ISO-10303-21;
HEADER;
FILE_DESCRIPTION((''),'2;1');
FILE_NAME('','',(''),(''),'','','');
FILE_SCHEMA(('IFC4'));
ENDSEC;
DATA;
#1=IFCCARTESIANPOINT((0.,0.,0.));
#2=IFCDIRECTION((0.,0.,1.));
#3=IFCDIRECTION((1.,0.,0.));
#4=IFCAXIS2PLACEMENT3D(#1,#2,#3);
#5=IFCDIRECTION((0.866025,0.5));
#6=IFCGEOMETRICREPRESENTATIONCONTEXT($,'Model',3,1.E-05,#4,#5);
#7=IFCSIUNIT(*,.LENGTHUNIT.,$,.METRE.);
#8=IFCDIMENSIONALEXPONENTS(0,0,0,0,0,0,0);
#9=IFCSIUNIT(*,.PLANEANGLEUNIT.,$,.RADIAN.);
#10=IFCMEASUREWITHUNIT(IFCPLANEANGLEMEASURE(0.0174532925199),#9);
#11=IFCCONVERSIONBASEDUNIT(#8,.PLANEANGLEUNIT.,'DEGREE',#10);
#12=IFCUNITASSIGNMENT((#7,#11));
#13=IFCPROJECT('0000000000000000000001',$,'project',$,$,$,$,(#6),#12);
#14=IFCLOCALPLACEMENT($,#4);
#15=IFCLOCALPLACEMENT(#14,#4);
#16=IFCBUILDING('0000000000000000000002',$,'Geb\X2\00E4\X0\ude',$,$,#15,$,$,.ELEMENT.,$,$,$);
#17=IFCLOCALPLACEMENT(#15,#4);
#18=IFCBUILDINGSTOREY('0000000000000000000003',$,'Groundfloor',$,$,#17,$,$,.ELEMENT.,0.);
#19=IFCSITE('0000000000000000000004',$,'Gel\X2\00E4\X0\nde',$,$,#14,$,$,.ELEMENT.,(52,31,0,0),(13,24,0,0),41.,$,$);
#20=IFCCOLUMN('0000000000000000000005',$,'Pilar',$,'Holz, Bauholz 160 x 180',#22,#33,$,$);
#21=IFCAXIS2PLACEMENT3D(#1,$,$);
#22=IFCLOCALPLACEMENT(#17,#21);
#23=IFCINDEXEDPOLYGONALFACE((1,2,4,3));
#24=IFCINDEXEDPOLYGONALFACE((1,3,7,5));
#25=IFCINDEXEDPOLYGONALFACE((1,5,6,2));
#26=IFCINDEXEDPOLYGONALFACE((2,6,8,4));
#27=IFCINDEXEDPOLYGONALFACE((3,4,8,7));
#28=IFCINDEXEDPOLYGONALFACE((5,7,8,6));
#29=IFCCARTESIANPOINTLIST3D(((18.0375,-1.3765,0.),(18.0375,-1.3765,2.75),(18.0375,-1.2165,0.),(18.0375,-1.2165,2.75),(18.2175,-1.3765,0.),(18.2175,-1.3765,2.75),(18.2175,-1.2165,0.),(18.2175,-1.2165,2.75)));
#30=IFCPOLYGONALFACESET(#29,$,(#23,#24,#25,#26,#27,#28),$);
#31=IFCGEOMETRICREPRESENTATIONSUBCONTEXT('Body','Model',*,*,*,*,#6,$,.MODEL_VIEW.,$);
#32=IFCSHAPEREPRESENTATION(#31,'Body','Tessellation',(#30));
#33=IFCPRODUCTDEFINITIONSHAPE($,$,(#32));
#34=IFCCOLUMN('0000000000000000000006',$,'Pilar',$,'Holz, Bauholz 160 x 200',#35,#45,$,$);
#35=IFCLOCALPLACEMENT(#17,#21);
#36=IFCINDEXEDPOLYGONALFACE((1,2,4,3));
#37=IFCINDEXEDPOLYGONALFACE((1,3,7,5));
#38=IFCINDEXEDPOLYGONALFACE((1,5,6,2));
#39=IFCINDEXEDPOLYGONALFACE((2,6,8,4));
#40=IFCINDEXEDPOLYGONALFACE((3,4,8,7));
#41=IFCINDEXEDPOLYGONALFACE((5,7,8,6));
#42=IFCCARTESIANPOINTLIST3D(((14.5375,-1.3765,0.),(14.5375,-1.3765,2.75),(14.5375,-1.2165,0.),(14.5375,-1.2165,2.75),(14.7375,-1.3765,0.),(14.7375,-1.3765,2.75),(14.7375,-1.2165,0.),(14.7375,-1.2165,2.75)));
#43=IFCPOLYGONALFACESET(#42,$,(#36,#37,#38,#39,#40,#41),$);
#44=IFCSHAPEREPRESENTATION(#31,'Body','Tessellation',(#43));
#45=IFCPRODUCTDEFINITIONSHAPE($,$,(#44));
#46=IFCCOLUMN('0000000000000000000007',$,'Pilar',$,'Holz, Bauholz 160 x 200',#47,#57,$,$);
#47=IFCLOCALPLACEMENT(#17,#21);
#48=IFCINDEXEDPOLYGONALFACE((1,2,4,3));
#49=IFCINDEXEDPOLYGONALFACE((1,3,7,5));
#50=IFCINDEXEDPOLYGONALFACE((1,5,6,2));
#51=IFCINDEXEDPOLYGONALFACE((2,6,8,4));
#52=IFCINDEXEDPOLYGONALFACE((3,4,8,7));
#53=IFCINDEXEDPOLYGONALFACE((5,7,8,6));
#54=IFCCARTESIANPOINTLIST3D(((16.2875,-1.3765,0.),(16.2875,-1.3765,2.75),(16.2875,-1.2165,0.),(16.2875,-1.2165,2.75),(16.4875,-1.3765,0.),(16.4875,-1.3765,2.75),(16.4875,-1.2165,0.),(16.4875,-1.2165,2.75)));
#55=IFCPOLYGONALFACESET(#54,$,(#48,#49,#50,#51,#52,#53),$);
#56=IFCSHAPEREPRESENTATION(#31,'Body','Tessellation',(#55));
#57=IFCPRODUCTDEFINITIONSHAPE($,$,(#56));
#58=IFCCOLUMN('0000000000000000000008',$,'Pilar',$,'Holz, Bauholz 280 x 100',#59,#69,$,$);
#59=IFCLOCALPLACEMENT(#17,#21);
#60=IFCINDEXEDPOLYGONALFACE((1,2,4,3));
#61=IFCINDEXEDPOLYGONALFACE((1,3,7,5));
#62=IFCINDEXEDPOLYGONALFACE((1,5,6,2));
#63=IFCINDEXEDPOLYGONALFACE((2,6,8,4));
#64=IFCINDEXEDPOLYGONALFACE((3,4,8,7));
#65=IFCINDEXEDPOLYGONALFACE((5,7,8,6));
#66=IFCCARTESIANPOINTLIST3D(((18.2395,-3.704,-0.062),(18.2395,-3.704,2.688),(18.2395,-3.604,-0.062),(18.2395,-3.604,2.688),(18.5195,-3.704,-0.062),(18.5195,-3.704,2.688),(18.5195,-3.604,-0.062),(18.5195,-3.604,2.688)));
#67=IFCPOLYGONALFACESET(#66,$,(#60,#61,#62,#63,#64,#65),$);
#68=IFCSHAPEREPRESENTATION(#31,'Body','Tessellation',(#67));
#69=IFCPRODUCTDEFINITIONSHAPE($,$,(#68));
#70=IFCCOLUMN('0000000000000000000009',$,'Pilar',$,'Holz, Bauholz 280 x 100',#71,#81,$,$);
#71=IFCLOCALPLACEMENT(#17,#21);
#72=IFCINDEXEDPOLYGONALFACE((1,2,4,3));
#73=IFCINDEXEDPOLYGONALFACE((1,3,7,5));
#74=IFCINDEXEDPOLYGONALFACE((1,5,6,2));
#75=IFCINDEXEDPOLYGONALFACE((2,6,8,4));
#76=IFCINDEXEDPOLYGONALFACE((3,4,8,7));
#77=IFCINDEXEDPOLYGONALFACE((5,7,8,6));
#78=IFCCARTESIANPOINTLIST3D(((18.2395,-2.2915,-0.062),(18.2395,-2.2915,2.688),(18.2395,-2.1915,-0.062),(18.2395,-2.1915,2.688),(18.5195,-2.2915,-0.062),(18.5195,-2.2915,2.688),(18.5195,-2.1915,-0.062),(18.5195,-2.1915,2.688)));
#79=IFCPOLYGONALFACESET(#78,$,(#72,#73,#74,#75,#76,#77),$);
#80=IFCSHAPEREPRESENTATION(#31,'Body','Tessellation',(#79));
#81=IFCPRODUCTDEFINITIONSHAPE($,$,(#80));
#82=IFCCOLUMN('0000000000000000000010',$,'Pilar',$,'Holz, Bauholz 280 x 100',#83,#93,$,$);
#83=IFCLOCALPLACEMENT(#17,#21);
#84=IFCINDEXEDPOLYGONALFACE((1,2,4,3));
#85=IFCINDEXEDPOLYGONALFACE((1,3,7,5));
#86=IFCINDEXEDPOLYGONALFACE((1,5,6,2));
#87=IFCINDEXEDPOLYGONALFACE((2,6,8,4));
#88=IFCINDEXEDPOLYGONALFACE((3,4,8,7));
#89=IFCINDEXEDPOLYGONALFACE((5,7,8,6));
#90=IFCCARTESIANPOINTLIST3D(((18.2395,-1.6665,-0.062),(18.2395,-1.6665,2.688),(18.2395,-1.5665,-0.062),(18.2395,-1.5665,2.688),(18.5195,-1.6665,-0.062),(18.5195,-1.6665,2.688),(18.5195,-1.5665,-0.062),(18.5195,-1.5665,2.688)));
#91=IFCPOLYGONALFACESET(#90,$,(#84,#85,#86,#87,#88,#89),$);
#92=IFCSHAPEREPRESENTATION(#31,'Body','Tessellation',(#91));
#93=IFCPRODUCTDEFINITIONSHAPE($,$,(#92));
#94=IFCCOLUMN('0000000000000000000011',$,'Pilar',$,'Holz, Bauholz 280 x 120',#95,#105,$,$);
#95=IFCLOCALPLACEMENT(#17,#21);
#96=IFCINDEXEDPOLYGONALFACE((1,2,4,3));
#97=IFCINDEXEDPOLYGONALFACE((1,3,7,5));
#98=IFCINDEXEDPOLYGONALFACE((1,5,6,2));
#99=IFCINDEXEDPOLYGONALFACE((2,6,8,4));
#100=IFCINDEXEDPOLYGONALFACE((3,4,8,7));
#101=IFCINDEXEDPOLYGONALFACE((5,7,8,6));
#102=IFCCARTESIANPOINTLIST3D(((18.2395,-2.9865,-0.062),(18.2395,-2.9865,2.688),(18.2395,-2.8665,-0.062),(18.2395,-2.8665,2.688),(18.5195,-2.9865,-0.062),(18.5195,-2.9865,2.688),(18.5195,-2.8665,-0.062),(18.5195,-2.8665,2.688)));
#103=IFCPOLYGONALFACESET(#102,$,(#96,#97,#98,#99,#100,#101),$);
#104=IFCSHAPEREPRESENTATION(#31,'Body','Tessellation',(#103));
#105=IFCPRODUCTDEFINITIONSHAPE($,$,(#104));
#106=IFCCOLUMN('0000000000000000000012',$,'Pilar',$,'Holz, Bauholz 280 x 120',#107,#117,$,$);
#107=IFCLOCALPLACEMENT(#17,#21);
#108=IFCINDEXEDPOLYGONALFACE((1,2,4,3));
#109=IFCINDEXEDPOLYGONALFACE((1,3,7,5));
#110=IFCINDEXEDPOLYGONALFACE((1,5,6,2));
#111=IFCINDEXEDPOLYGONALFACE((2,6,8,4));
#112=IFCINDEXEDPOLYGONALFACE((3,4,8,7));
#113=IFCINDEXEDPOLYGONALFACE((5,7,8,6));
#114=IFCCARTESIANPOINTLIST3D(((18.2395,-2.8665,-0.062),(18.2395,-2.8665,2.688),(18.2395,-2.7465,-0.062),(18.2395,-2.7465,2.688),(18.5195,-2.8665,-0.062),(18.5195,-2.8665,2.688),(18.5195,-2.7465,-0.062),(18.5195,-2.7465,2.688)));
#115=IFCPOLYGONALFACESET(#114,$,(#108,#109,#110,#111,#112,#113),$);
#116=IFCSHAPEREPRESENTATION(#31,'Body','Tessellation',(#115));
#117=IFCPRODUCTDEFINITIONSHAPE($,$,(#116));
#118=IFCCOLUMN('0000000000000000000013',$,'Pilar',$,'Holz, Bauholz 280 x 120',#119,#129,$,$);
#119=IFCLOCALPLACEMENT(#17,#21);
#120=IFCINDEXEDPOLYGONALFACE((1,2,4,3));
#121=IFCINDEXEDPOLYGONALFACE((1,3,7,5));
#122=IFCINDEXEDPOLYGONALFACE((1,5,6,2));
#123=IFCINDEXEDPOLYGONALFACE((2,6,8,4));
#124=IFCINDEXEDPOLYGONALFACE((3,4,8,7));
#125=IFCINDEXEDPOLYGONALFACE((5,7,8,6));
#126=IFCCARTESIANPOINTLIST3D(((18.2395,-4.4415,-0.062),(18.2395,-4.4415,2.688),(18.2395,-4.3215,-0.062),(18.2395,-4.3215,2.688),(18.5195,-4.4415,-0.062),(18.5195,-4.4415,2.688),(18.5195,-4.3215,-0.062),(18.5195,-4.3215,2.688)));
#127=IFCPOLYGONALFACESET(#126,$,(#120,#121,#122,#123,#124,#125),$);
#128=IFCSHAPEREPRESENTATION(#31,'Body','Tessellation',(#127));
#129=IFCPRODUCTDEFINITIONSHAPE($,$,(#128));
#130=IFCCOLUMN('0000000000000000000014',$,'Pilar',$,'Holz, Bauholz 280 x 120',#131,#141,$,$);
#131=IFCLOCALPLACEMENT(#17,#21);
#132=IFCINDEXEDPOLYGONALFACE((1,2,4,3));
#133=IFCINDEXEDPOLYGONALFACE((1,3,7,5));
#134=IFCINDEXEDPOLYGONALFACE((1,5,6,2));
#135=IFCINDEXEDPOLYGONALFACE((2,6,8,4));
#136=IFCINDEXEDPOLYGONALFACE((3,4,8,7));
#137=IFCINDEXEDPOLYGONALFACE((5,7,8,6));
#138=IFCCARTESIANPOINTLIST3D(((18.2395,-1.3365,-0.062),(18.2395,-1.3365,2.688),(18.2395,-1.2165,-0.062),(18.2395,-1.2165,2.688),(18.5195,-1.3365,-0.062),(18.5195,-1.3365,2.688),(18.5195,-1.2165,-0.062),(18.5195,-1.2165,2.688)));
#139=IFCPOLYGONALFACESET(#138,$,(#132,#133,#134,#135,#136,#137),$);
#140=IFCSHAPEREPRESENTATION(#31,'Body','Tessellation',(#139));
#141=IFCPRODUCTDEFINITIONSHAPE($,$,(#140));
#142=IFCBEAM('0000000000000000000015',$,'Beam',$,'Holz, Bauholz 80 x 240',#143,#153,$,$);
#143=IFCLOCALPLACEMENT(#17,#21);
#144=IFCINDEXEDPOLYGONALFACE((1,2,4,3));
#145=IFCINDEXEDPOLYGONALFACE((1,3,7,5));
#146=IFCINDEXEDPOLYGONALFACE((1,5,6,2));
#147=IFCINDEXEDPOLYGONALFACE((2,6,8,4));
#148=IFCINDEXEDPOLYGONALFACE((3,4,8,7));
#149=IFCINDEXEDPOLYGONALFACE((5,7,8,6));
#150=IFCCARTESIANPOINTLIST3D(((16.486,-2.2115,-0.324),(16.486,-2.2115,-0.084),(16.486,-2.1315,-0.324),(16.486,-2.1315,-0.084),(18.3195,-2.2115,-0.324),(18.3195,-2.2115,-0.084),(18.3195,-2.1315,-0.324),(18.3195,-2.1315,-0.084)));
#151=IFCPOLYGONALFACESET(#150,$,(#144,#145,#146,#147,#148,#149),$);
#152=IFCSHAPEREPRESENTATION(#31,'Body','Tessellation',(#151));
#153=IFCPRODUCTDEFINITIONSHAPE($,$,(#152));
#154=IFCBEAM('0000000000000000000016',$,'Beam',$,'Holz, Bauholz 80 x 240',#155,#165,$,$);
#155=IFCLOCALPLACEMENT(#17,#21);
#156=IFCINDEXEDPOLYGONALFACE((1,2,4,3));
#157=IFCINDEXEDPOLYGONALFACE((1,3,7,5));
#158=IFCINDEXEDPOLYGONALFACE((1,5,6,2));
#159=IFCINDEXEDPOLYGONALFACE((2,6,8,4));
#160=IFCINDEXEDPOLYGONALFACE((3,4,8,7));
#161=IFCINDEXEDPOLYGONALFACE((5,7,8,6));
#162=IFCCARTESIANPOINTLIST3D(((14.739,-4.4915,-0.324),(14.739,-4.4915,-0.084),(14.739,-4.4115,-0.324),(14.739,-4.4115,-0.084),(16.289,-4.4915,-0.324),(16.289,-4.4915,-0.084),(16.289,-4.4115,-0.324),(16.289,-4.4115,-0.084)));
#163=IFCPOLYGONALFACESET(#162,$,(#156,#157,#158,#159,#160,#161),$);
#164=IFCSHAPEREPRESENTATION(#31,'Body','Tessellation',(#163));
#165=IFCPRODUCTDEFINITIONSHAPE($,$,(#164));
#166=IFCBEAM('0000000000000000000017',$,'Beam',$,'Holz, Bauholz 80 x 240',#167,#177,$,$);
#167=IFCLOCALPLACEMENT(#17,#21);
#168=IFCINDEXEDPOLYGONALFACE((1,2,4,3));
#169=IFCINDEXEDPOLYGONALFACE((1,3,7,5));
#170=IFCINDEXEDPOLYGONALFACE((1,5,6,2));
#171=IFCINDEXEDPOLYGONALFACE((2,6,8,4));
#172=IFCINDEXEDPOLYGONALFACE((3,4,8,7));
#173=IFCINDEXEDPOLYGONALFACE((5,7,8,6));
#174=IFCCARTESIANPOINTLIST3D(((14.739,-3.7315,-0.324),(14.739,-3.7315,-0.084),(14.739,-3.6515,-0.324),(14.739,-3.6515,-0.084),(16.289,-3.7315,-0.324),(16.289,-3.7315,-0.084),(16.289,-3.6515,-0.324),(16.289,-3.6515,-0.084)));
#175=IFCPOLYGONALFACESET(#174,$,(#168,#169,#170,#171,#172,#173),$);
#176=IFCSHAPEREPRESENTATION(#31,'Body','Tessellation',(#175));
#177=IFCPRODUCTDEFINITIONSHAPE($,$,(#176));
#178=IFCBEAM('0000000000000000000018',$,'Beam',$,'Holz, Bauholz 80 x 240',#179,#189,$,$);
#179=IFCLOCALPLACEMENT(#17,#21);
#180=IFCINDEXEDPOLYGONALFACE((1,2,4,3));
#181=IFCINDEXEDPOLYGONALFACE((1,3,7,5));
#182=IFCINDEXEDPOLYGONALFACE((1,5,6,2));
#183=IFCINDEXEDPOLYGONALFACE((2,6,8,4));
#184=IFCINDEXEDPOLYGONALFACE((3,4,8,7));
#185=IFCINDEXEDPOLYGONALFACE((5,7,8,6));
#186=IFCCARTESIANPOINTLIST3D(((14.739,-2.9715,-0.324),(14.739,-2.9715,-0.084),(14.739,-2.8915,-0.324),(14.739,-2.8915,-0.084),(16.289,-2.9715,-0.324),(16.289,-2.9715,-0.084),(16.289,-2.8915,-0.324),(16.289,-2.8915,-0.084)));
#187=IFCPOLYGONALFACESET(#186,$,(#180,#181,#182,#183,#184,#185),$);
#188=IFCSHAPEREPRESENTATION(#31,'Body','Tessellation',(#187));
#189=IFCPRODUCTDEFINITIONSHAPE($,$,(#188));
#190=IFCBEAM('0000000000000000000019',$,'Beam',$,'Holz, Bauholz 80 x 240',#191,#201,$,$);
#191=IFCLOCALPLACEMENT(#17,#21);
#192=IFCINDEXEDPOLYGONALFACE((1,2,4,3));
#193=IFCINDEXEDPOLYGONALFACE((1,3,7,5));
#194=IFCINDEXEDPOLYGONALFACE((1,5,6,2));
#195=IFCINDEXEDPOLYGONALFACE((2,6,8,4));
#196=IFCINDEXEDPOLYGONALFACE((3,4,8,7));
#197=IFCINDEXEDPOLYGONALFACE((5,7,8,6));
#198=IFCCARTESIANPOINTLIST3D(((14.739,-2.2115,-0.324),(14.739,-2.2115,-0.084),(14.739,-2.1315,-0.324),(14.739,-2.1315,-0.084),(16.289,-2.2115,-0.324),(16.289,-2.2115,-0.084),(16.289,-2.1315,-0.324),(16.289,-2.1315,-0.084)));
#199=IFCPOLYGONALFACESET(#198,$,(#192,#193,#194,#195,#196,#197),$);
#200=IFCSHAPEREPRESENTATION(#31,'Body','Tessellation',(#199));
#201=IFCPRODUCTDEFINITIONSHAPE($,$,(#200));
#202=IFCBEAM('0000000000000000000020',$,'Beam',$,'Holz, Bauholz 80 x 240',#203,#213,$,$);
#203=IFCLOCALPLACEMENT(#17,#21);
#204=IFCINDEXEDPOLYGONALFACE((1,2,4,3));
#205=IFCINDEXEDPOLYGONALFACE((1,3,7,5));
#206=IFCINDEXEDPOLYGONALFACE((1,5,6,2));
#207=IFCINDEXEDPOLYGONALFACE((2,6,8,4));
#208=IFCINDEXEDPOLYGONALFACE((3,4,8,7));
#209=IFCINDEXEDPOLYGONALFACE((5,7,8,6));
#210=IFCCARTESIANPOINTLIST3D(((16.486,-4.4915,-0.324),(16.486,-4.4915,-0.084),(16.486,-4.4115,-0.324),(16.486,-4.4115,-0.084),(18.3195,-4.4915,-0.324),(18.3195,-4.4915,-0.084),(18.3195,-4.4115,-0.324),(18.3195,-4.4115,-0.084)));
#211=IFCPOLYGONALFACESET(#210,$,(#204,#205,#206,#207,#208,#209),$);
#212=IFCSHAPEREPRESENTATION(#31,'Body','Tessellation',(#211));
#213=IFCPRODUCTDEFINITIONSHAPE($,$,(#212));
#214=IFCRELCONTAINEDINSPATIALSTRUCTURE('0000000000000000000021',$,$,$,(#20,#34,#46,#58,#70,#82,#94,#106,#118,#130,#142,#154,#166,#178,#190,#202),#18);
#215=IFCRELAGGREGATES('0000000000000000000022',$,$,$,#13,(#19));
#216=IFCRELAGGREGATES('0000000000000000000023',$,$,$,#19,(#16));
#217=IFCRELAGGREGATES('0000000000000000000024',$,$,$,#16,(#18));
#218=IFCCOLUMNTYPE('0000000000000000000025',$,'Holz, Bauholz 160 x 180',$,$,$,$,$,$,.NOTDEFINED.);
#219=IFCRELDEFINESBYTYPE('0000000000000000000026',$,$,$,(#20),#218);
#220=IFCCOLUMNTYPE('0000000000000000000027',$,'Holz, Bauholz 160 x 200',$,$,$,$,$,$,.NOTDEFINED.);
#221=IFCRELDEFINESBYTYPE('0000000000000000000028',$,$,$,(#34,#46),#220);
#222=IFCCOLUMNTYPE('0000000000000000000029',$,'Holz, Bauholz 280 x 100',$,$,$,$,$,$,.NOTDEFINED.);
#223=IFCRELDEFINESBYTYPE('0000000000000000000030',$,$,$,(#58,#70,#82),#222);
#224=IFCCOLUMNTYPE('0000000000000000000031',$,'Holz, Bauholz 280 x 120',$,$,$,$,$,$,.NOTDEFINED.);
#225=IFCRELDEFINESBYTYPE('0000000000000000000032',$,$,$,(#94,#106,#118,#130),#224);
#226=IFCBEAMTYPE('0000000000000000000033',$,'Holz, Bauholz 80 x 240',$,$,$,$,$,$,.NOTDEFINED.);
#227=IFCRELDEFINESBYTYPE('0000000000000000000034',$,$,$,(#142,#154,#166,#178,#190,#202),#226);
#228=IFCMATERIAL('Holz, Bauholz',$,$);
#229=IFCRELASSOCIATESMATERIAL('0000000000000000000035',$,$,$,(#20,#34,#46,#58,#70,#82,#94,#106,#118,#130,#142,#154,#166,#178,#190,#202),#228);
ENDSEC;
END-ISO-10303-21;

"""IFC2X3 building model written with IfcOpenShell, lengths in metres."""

from ifc_helpers import new_model, entity, si_unit, converted_unit, direction, frame, frame_2d, origin_with_axes, origin_2d_with_axis, place, context, subcontext, project, spatial, rectangle, extrude, clip, halfspace, material, type_object, element, save


model = new_model("IFC2X3")

# Units and contexts
model_context = context("Model", 3, precision=1e-05, world=origin_with_axes(), true_north=direction((0.866025, 0.5)))
body_context = subcontext(model_context, "Body", "Model", "MODEL_VIEW")
ifc_project = project(units=[si_unit("LENGTHUNIT", "METRE"), converted_unit("PLANEANGLEUNIT", "DEGREE", entity("IfcPlaneAngleMeasure", 0.0174532925199), si_unit("PLANEANGLEUNIT", "RADIAN"), dimensions=[0, 0, 0, 0, 0, 0, 0])], contexts=[model_context])

# Site, building, storey
site_placement = place(None, origin_with_axes())
site = spatial("IfcSite", under=ifc_project, at=site_placement, Name="Gelände", CompositionType="ELEMENT", RefLatitude=(52, 31, 0, 0), RefLongitude=(13, 24, 0, 0), RefElevation=41.0)
building_placement = place(site_placement, origin_with_axes())
building = spatial("IfcBuilding", under=site, at=building_placement, Name="Gebäude", CompositionType="ELEMENT")
storey_placement = place(building_placement, origin_with_axes())
storey = spatial("IfcBuildingStorey", under=building, at=storey_placement, Name="Groundfloor", CompositionType="ELEMENT", Elevation=0.0)

# Columns
ifc_material_1 = material(Name="Holz, Bauholz")
column_type_1 = type_object("IfcColumnType", Name="Holz, Bauholz 160 x 180", PredefinedType="NOTDEFINED")
column_placement = place(storey_placement, frame((18.1275, -1.2965, 0.0), z_axis=(0.0, 0.0, 1.0), x_axis=(1.0, 0.0, 0.0)))
element("IfcColumn", 1, at=column_placement, inside=storey, type_object=column_type_1, material=ifc_material_1, Name="Pilar", ObjectType="Holz, Bauholz 160 x 180", context=body_context, shape_type="Clipping", body=[
    clip(clip(extrude(rectangle(XDim=0.16, YDim=0.18, at=origin_2d_with_axis()), frame((0.0, 0.0, 0.0), z_axis=(0.0, 0.0, 1.0), x_axis=(0.0, 1.0, 0.0)), (0.0, 0.0, 1.0), 2.75), halfspace(frame((0.0, 0.0, 2.75), z_axis=(0.0, 0.0, -1.0), x_axis=(0.0, 1.0, 0.0)), True)), halfspace(frame((0.0, 0.0, 0.0), z_axis=(0.0, 0.0, 1.0), x_axis=(0.0, -1.0, 0.0)), True)),
])
column_type_2 = type_object("IfcColumnType", Name="Holz, Bauholz 160 x 200", PredefinedType="NOTDEFINED")
for number, where, z_axis, x_axis, name in (
    (2, (14.6375, -1.2965, 0.0), (0.0, 0.0, 1.0), (1.0, 0.0, 0.0), "Pilar"),
    (3, (16.3875, -1.2965, 0.0), (0.0, 0.0, 1.0), (1.0, 0.0, 0.0), "Pilar"),
):
    element("IfcColumn", number, at=place(storey_placement, frame(where, z_axis=z_axis, x_axis=x_axis)), inside=storey, type_object=column_type_2, material=ifc_material_1, Name=name, ObjectType="Holz, Bauholz 160 x 200", context=body_context, shape_type="Clipping", body=[
        clip(clip(extrude(rectangle(XDim=0.16, YDim=0.2, at=origin_2d_with_axis()), frame((0.0, 0.0, 0.0), z_axis=(0.0, 0.0, 1.0), x_axis=(0.0, 1.0, 0.0)), (0.0, 0.0, 1.0), 2.75), halfspace(frame((0.0, 0.0, 2.75), z_axis=(0.0, 0.0, -1.0), x_axis=(0.0, 1.0, 0.0)), True)), halfspace(frame((0.0, 0.0, 0.0), z_axis=(0.0, 0.0, 1.0), x_axis=(0.0, -1.0, 0.0)), True)),
    ])
column_type_3 = type_object("IfcColumnType", Name="Holz, Bauholz 280 x 100", PredefinedType="NOTDEFINED")
for number, where, z_axis, x_axis, name in (
    (4, (18.3795, -3.654, -0.062), (0.0, 0.0, 1.0), (0.0, 1.0, 0.0), "Pilar"),
    (5, (18.3795, -2.2415, -0.062), (0.0, 0.0, 1.0), (0.0, 1.0, 0.0), "Pilar"),
    (6, (18.3795, -1.6165, -0.062), (0.0, 0.0, 1.0), (0.0, 1.0, 0.0), "Pilar"),
):
    element("IfcColumn", number, at=place(storey_placement, frame(where, z_axis=z_axis, x_axis=x_axis)), inside=storey, type_object=column_type_3, material=ifc_material_1, Name=name, ObjectType="Holz, Bauholz 280 x 100", context=body_context, shape_type="Clipping", body=[
        clip(clip(extrude(rectangle(XDim=0.28, YDim=0.1, at=origin_2d_with_axis()), frame((0.0, 0.0, 0.0), z_axis=(0.0, 0.0, 1.0), x_axis=(0.0, 1.0, 0.0)), (0.0, 0.0, 1.0), 2.75), halfspace(frame((0.0, 0.0, 2.75), z_axis=(0.0, 0.0, -1.0), x_axis=(0.0, 1.0, 0.0)), True)), halfspace(frame((0.0, 0.0, 0.0), z_axis=(0.0, 0.0, 1.0), x_axis=(0.0, -1.0, 0.0)), True)),
    ])
column_type_4 = type_object("IfcColumnType", Name="Holz, Bauholz 280 x 120", PredefinedType="NOTDEFINED")
for number, where, z_axis, x_axis, name in (
    (7, (18.3795, -2.9265, -0.062), (0.0, 0.0, 1.0), (0.0, 1.0, 0.0), "Pilar"),
    (8, (18.3795, -2.8065, -0.062), (0.0, 0.0, 1.0), (0.0, 1.0, 0.0), "Pilar"),
    (9, (18.3795, -4.3815, -0.062), (0.0, 0.0, 1.0), (0.0, 1.0, 0.0), "Pilar"),
    (10, (18.3795, -1.2765, -0.062), (0.0, 0.0, 1.0), (0.0, 1.0, 0.0), "Pilar"),
):
    element("IfcColumn", number, at=place(storey_placement, frame(where, z_axis=z_axis, x_axis=x_axis)), inside=storey, type_object=column_type_4, material=ifc_material_1, Name=name, ObjectType="Holz, Bauholz 280 x 120", context=body_context, shape_type="Clipping", body=[
        clip(clip(extrude(rectangle(XDim=0.28, YDim=0.12, at=origin_2d_with_axis()), frame((0.0, 0.0, 0.0), z_axis=(0.0, 0.0, 1.0), x_axis=(0.0, 1.0, 0.0)), (0.0, 0.0, 1.0), 2.75), halfspace(frame((0.0, 0.0, 2.75), z_axis=(0.0, 0.0, -1.0), x_axis=(0.0, 1.0, 0.0)), True)), halfspace(frame((0.0, 0.0, 0.0), z_axis=(0.0, 0.0, 1.0), x_axis=(0.0, -1.0, 0.0)), True)),
    ])

# Beams
beam_type_1 = type_object("IfcBeamType", Name="Holz, Bauholz 80 x 240", PredefinedType="NOTDEFINED")
beam_1_placement = place(storey_placement, frame((18.3195, -2.1715, -0.084), z_axis=(0.0, 0.0, 1.0), x_axis=(0.0, 1.0, 0.0)))
element("IfcBeam", 11, at=beam_1_placement, inside=storey, type_object=beam_type_1, material=ifc_material_1, Name="Beam", ObjectType="Holz, Bauholz 80 x 240", context=body_context, shape_type="SweptSolid", body=[
    extrude(rectangle(XDim=0.24, YDim=0.08, at=frame_2d((-0.12, 0.0), x_axis=(1.0, 0.0))), frame((0.0, 0.0, 0.0), z_axis=(0.0, 1.0, 0.0), x_axis=(0.0, 0.0, 1.0)), (0.0, 0.0, 1.0), 1.8335),
])
for number, where, z_axis, x_axis, name in (
    (12, (16.289, -4.4515, -0.084), (0.0, 0.0, 1.0), (0.0, 1.0, 0.0), "Beam"),
    (13, (16.289, -3.6915, -0.084), (0.0, 0.0, 1.0), (0.0, 1.0, 0.0), "Beam"),
    (14, (16.289, -2.9315, -0.084), (0.0, 0.0, 1.0), (0.0, 1.0, 0.0), "Beam"),
    (15, (16.289, -2.1715, -0.084), (0.0, 0.0, 1.0), (0.0, 1.0, 0.0), "Beam"),
):
    element("IfcBeam", number, at=place(storey_placement, frame(where, z_axis=z_axis, x_axis=x_axis)), inside=storey, type_object=beam_type_1, material=ifc_material_1, Name=name, ObjectType="Holz, Bauholz 80 x 240", context=body_context, shape_type="SweptSolid", body=[
        extrude(rectangle(XDim=0.24, YDim=0.08, at=frame_2d((-0.12, 0.0), x_axis=(1.0, 0.0))), frame((0.0, 0.0, 0.0), z_axis=(0.0, 1.0, 0.0), x_axis=(0.0, 0.0, 1.0)), (0.0, 0.0, 1.0), 1.55),
    ])
for number, where, z_axis, x_axis, name in (
    (16, (18.3195, -4.4515, -0.084), (0.0, 0.0, 1.0), (0.0, 1.0, 0.0), "Beam"),
):
    element("IfcBeam", number, at=place(storey_placement, frame(where, z_axis=z_axis, x_axis=x_axis)), inside=storey, type_object=beam_type_1, material=ifc_material_1, Name=name, ObjectType="Holz, Bauholz 80 x 240", context=body_context, shape_type="SweptSolid", body=[
        extrude(rectangle(XDim=0.24, YDim=0.08, at=frame_2d((-0.12, 0.0), x_axis=(1.0, 0.0))), frame((0.0, 0.0, 0.0), z_axis=(0.0, 1.0, 0.0), x_axis=(0.0, 0.0, 1.0)), (0.0, 0.0, 1.0), 1.8335),
    ])

save(model, "model.ifc")
